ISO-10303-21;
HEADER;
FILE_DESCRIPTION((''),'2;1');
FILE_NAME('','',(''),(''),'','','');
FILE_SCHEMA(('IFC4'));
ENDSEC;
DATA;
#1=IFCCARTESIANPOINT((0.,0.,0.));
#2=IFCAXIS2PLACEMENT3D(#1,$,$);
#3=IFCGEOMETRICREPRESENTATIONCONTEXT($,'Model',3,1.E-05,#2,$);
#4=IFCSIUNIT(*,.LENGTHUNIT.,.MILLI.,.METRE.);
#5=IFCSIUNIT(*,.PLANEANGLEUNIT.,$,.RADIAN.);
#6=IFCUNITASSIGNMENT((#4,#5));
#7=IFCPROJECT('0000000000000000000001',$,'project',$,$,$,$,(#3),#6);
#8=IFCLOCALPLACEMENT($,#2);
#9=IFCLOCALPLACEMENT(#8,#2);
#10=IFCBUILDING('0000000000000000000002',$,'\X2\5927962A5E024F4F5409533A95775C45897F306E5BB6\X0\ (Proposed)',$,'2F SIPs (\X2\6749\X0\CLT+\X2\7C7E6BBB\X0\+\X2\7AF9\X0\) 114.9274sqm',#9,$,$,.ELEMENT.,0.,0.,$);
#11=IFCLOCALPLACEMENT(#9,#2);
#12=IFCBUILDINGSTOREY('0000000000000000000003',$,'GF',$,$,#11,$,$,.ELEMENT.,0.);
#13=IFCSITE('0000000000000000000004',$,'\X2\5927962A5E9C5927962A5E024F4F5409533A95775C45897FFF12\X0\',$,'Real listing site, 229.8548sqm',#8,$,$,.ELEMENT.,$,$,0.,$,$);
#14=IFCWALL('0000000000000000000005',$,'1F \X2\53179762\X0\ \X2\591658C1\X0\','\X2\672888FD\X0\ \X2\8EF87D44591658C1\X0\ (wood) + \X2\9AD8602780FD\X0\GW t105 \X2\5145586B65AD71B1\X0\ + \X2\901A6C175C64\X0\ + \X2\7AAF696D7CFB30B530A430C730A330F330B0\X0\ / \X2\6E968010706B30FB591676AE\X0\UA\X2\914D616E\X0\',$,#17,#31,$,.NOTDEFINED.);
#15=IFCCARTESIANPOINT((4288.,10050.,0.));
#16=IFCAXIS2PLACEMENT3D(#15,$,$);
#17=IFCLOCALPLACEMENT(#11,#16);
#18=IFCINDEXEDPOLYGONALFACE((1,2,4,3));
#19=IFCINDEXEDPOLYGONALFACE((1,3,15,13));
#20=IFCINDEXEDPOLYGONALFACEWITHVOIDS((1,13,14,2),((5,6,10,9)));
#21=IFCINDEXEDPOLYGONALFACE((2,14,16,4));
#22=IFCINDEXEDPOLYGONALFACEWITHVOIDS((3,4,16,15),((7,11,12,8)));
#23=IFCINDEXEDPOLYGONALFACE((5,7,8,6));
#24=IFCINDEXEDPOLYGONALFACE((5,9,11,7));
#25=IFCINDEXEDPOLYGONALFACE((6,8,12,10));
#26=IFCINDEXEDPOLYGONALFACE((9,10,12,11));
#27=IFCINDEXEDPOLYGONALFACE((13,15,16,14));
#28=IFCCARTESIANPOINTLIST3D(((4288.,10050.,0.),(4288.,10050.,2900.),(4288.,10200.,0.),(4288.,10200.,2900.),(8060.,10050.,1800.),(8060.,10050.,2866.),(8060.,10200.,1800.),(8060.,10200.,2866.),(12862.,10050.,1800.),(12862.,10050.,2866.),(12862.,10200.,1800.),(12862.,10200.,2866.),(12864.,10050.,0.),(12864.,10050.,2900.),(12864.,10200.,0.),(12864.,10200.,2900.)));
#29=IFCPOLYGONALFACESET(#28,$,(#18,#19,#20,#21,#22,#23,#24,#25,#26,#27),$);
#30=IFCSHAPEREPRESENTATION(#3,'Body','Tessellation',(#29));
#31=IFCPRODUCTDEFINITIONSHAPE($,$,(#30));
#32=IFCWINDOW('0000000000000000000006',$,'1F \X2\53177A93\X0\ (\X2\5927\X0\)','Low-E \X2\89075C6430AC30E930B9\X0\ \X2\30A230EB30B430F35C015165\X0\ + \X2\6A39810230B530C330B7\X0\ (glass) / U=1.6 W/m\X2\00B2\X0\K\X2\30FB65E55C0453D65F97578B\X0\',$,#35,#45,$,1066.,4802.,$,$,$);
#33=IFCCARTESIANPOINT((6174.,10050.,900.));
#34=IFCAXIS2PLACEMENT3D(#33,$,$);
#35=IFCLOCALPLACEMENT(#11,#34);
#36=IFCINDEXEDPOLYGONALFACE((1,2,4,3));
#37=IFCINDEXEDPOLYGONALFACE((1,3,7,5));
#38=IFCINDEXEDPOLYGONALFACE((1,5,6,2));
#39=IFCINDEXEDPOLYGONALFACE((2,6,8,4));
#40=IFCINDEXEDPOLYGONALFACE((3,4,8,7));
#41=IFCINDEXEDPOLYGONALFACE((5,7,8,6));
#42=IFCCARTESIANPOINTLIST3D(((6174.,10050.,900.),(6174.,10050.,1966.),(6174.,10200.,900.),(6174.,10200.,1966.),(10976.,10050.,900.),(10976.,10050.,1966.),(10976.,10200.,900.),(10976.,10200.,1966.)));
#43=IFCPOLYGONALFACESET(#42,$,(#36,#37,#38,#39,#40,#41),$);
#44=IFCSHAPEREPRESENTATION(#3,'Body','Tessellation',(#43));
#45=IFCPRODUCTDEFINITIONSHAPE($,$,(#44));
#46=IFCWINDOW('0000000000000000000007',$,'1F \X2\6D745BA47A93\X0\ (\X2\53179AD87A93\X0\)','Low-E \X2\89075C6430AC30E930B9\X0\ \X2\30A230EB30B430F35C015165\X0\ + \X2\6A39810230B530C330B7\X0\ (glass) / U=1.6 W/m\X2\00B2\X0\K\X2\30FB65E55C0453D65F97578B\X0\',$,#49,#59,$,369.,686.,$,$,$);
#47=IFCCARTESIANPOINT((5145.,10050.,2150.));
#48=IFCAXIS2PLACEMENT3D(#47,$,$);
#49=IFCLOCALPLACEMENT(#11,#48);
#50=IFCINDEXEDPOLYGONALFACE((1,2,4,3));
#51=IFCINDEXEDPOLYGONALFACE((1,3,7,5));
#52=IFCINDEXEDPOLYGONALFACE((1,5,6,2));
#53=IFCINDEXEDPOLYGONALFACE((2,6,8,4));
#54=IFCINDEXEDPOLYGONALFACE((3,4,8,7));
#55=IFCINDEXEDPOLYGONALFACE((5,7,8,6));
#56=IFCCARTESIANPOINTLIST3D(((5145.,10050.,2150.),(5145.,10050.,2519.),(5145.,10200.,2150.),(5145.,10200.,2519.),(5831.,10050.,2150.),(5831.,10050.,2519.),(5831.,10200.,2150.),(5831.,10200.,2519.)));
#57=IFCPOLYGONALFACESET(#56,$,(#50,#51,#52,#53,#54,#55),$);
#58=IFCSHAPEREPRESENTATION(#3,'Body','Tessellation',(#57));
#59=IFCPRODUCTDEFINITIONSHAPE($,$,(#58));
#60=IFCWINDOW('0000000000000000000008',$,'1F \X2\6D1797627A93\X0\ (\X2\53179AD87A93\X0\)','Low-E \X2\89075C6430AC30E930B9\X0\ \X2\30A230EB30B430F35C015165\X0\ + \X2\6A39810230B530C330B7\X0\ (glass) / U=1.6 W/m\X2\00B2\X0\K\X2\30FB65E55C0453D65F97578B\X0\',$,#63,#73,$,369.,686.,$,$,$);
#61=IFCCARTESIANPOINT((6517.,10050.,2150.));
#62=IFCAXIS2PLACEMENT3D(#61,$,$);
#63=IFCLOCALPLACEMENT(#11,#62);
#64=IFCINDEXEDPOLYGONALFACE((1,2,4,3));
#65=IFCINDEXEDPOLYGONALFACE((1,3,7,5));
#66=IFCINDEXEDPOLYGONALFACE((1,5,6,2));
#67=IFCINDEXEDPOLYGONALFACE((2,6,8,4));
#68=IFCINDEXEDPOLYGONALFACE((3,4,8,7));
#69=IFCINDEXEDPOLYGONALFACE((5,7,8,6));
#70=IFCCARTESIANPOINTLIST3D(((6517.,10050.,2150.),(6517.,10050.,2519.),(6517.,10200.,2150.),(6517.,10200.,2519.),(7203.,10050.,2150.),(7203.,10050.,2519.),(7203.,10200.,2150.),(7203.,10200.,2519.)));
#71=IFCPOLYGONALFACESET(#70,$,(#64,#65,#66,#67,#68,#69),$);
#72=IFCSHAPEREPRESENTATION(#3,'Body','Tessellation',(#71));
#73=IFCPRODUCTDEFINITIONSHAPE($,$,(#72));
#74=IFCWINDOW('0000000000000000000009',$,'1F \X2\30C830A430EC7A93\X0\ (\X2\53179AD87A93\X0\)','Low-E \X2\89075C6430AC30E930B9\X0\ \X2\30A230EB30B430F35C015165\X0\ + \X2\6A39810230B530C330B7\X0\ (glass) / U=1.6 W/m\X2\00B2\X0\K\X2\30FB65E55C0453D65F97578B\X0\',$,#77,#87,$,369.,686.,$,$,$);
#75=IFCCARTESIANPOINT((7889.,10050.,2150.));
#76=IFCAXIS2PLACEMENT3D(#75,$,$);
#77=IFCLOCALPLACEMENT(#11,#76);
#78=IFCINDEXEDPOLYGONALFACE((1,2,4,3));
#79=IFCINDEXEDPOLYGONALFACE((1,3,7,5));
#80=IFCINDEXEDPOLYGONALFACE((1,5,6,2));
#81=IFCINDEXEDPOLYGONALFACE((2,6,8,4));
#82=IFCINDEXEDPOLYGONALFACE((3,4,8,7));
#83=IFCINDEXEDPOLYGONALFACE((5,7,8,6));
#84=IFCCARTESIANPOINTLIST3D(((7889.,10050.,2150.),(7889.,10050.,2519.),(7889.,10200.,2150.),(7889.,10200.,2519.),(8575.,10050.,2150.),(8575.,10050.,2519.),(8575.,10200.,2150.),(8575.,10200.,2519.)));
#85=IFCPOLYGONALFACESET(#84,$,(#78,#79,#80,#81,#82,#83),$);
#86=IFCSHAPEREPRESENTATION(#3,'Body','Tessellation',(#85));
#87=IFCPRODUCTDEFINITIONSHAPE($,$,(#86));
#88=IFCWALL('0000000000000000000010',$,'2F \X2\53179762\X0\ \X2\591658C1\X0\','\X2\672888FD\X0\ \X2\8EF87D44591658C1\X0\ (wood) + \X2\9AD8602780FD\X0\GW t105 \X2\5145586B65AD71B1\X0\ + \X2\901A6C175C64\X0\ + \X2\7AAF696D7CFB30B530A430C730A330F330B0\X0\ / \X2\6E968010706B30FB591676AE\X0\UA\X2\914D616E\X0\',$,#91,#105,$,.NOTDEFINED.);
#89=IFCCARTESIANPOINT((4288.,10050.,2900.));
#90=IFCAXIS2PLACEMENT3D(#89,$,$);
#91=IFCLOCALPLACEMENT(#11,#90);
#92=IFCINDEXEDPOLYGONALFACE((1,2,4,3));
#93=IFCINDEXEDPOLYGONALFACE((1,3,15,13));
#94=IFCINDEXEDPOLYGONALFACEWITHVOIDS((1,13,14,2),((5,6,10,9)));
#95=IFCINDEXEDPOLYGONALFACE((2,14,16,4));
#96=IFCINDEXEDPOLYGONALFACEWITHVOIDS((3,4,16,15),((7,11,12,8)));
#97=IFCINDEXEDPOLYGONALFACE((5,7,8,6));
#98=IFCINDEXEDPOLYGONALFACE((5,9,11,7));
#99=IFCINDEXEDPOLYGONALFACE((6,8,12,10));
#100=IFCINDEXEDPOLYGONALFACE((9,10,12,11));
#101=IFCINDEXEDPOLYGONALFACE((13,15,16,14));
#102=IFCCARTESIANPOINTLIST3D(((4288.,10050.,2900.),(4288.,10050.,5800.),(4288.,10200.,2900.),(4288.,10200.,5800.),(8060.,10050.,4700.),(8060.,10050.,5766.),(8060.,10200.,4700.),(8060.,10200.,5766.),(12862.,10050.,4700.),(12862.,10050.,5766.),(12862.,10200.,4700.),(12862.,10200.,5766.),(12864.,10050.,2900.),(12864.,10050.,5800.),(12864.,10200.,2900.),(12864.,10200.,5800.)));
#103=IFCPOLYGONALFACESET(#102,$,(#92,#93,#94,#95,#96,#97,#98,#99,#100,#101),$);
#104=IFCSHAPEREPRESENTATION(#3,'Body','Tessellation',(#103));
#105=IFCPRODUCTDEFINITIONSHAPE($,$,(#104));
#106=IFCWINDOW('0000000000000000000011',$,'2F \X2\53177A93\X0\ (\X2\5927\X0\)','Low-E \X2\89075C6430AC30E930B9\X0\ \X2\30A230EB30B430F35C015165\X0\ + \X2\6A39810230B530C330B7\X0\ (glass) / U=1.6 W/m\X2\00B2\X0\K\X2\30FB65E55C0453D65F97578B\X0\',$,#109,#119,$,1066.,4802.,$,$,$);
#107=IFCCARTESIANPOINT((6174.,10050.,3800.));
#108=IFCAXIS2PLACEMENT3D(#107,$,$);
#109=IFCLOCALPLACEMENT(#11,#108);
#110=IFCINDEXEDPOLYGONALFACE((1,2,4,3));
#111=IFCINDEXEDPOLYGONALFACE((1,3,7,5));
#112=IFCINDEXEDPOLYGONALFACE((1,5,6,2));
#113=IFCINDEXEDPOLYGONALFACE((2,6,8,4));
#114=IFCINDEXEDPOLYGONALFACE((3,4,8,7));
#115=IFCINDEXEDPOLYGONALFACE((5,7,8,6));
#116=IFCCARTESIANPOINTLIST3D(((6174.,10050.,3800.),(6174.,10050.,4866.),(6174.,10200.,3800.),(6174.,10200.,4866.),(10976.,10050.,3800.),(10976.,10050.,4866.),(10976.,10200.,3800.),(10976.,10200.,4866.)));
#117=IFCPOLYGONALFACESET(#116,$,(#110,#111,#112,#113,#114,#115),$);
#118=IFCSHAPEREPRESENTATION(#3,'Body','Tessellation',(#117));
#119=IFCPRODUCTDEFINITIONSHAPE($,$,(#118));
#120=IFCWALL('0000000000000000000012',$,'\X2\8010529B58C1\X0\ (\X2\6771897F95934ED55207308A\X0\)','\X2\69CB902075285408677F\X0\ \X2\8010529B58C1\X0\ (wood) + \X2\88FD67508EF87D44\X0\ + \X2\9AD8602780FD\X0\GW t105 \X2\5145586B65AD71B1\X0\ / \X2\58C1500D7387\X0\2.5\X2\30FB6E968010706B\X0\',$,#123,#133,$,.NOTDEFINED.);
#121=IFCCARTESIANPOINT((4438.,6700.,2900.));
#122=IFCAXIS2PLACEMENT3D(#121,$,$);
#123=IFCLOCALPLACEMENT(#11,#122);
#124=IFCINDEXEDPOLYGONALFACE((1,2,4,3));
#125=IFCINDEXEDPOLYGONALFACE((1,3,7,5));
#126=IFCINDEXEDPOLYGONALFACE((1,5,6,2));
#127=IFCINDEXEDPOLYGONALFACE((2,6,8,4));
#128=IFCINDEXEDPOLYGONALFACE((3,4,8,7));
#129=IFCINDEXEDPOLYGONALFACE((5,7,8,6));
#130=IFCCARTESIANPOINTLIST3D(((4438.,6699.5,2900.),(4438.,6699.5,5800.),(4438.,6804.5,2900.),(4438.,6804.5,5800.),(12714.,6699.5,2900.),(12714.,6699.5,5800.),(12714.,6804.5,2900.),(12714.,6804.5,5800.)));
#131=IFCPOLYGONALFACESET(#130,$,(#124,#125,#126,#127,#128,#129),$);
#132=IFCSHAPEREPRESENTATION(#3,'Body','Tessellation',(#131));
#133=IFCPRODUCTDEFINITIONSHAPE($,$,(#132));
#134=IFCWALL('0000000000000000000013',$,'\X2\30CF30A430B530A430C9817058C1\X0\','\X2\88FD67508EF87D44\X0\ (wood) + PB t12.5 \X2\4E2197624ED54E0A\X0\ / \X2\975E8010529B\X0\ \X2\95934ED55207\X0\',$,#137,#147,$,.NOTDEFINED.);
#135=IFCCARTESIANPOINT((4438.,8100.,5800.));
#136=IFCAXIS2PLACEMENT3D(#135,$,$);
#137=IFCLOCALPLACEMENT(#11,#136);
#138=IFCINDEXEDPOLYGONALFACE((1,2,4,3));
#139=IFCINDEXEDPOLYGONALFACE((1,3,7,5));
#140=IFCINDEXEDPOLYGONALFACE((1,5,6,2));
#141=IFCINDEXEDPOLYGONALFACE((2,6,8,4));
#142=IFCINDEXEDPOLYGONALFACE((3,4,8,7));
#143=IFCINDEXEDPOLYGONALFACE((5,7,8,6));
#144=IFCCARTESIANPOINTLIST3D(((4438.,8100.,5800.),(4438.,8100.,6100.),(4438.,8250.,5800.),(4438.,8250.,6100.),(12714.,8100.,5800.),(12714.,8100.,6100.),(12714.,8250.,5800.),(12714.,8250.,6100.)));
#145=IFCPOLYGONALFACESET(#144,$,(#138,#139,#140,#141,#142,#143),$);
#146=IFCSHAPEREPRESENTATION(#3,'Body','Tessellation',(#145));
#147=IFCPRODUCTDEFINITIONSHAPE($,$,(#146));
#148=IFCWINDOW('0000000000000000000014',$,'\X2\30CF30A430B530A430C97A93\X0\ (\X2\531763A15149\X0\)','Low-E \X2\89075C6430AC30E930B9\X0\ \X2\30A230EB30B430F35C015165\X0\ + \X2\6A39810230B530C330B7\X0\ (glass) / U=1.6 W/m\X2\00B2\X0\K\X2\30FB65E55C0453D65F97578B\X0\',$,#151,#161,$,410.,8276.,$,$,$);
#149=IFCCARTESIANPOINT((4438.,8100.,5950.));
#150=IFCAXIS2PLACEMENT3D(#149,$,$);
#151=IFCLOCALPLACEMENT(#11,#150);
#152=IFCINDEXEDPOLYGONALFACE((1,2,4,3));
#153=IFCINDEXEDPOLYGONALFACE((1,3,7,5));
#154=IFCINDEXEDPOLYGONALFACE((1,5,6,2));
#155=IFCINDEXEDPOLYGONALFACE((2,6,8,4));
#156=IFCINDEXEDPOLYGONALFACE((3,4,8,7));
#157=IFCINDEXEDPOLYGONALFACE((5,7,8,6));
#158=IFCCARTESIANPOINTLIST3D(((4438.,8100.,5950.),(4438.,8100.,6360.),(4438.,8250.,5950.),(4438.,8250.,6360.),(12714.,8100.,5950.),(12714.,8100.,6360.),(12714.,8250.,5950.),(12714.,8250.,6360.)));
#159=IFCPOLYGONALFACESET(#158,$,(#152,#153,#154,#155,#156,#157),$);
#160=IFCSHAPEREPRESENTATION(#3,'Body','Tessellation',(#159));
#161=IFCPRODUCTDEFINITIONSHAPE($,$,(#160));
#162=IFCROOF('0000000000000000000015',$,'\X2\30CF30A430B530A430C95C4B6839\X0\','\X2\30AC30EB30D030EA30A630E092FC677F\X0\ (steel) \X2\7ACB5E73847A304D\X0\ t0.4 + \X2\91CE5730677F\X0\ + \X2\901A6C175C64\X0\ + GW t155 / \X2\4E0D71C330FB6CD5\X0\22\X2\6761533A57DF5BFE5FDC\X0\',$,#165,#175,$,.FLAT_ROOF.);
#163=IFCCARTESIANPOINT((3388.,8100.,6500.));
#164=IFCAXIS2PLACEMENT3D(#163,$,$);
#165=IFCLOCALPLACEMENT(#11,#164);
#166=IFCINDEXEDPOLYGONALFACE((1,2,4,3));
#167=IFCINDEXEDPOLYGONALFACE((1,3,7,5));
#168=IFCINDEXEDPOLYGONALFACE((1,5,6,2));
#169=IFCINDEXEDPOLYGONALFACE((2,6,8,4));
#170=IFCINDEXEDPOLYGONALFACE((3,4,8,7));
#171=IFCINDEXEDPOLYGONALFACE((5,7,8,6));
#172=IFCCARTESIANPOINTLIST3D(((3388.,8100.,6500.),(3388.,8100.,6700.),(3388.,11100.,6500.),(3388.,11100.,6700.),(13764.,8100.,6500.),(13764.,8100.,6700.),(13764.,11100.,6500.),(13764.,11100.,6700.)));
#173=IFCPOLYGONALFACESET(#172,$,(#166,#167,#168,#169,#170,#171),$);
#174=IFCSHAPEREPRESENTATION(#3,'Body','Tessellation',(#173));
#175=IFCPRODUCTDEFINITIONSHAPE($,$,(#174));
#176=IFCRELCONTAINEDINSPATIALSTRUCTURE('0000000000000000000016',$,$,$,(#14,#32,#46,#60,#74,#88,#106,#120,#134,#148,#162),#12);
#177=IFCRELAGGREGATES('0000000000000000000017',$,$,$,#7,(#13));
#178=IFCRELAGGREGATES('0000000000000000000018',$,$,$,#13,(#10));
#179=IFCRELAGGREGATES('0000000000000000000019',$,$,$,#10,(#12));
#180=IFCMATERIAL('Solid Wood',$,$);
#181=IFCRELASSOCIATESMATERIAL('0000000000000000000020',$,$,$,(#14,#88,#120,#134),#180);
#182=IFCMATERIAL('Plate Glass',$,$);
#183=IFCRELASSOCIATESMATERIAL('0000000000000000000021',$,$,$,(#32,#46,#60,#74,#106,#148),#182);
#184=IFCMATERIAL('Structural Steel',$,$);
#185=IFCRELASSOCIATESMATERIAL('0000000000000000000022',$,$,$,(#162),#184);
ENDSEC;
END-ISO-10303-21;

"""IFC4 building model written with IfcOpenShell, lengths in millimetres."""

from ifc_helpers import new_model, si_unit, frame, frame_2d, origin, place, context, project, spatial, rectangle, extrude, material, element, fill, save


model = new_model("IFC4")

# Units and contexts
model_context = context("Model", 3, precision=1e-05, world=origin())
ifc_project = project(units=[si_unit("LENGTHUNIT", "METRE", prefix="MILLI"), si_unit("PLANEANGLEUNIT", "RADIAN")], contexts=[model_context])

# Site, building, storey
site_placement = place(None, origin())
site = spatial("IfcSite", under=ifc_project, at=site_placement, Name="大阪府大阪市住吉区長居西２", ObjectType="Real listing site, 229.8548sqm", CompositionType="ELEMENT", RefElevation=0.0)
building_placement = place(site_placement, origin())
building = spatial("IfcBuilding", under=site, at=building_placement, Name="大阪市住吉区長居西の家 (Proposed)", ObjectType="2F SIPs (杉CLT+籾殻+竹) 114.9274sqm", CompositionType="ELEMENT", ElevationOfRefHeight=0.0, ElevationOfTerrain=0.0)
storey_placement = place(building_placement, origin())
storey = spatial("IfcBuildingStorey", under=building, at=storey_placement, Name="GF", CompositionType="ELEMENT", Elevation=0.0)

# Wall, openings, windows
ifc_material_1 = material(Name="Solid Wood")
wall_1_placement = place(storey_placement, frame((4288.0, 10050.0, 0.0)))
wall_1 = element("IfcWall", 1, at=wall_1_placement, inside=storey, material=ifc_material_1, Name="1F 北面 外壁", Description="木製 軸組外壁 (wood) + 高性能GW t105 充填断熱 + 通気層 + 窯業系サイディング / 準耐火・外皮UA配慮", PredefinedType="NOTDEFINED", context=model_context, shape_type="SweptSolid", body=[
    extrude(rectangle(XDim=8576.0, YDim=150.0, at=frame_2d((4288.0, 75.0))), frame((4288.0, 10050.0, 0.0)), (0.0, 0.0, 1.0), 2900.0),
])
opening_1_placement = place(storey_placement, frame((6174.0, 10050.0, 900.0)))
opening_1 = element("IfcOpeningElement", 2, at=opening_1_placement, cuts=wall_1, PredefinedType="NOTDEFINED", context=model_context, shape_type="SweptSolid", body=[
    extrude(rectangle(XDim=4802.0, YDim=150.0, at=frame_2d((2401.0, 75.0))), frame((6174.0, 10050.0, 900.0)), (0.0, 0.0, 1.0), 1066.0),
])
opening_2_placement = place(storey_placement, frame((5145.0, 10050.0, 2150.0)))
opening_2 = element("IfcOpeningElement", 3, at=opening_2_placement, cuts=wall_1, PredefinedType="NOTDEFINED", context=model_context, shape_type="SweptSolid", body=[
    extrude(rectangle(XDim=686.0, YDim=150.0, at=frame_2d((343.0, 75.0))), frame((5145.0, 10050.0, 2150.0)), (0.0, 0.0, 1.0), 369.0),
])
opening_3_placement = place(storey_placement, frame((6517.0, 10050.0, 2150.0)))
opening_3 = element("IfcOpeningElement", 4, at=opening_3_placement, cuts=wall_1, PredefinedType="NOTDEFINED", context=model_context, shape_type="SweptSolid", body=[
    extrude(rectangle(XDim=686.0, YDim=150.0, at=frame_2d((343.0, 75.0))), frame((6517.0, 10050.0, 2150.0)), (0.0, 0.0, 1.0), 369.0),
])
opening_4_placement = place(storey_placement, frame((7889.0, 10050.0, 2150.0)))
opening_4 = element("IfcOpeningElement", 5, at=opening_4_placement, cuts=wall_1, PredefinedType="NOTDEFINED", context=model_context, shape_type="SweptSolid", body=[
    extrude(rectangle(XDim=686.0, YDim=150.0, at=frame_2d((343.0, 75.0))), frame((7889.0, 10050.0, 2150.0)), (0.0, 0.0, 1.0), 369.0),
])
ifc_material_2 = material(Name="Plate Glass")
window_1_placement = place(storey_placement, frame((6174.0, 10050.0, 900.0)))
window_1 = element("IfcWindow", 6, at=window_1_placement, inside=storey, material=ifc_material_2, Name="1F 北窓 (大)", Description="Low-E 複層ガラス アルゴン封入 + 樹脂サッシ (glass) / U=1.6 W/m²K・日射取得型", OverallHeight=1066.0, OverallWidth=4802.0, context=model_context, shape_type="SweptSolid", body=[
    extrude(rectangle(XDim=4802.0, YDim=150.0, at=frame_2d((2401.0, 75.0))), frame((6174.0, 10050.0, 900.0)), (0.0, 0.0, 1.0), 1066.0),
])
fill(opening_1, window_1)
window_2_placement = place(storey_placement, frame((5145.0, 10050.0, 2150.0)))
window_2 = element("IfcWindow", 7, at=window_2_placement, inside=storey, material=ifc_material_2, Name="1F 浴室窓 (北高窓)", Description="Low-E 複層ガラス アルゴン封入 + 樹脂サッシ (glass) / U=1.6 W/m²K・日射取得型", OverallHeight=369.0, OverallWidth=686.0, context=model_context, shape_type="SweptSolid", body=[
    extrude(rectangle(XDim=686.0, YDim=150.0, at=frame_2d((343.0, 75.0))), frame((5145.0, 10050.0, 2150.0)), (0.0, 0.0, 1.0), 369.0),
])
fill(opening_2, window_2)
window_3_placement = place(storey_placement, frame((6517.0, 10050.0, 2150.0)))
window_3 = element("IfcWindow", 8, at=window_3_placement, inside=storey, material=ifc_material_2, Name="1F 洗面窓 (北高窓)", Description="Low-E 複層ガラス アルゴン封入 + 樹脂サッシ (glass) / U=1.6 W/m²K・日射取得型", OverallHeight=369.0, OverallWidth=686.0, context=model_context, shape_type="SweptSolid", body=[
    extrude(rectangle(XDim=686.0, YDim=150.0, at=frame_2d((343.0, 75.0))), frame((6517.0, 10050.0, 2150.0)), (0.0, 0.0, 1.0), 369.0),
])
fill(opening_3, window_3)
window_4_placement = place(storey_placement, frame((7889.0, 10050.0, 2150.0)))
window_4 = element("IfcWindow", 9, at=window_4_placement, inside=storey, material=ifc_material_2, Name="1F トイレ窓 (北高窓)", Description="Low-E 複層ガラス アルゴン封入 + 樹脂サッシ (glass) / U=1.6 W/m²K・日射取得型", OverallHeight=369.0, OverallWidth=686.0, context=model_context, shape_type="SweptSolid", body=[
    extrude(rectangle(XDim=686.0, YDim=150.0, at=frame_2d((343.0, 75.0))), frame((7889.0, 10050.0, 2150.0)), (0.0, 0.0, 1.0), 369.0),
])
fill(opening_4, window_4)

# Wall, opening, window
wall_2_placement = place(storey_placement, frame((4288.0, 10050.0, 2900.0)))
wall_2 = element("IfcWall", 10, at=wall_2_placement, inside=storey, material=ifc_material_1, Name="2F 北面 外壁", Description="木製 軸組外壁 (wood) + 高性能GW t105 充填断熱 + 通気層 + 窯業系サイディング / 準耐火・外皮UA配慮", PredefinedType="NOTDEFINED", context=model_context, shape_type="SweptSolid", body=[
    extrude(rectangle(XDim=8576.0, YDim=150.0, at=frame_2d((4288.0, 75.0))), frame((4288.0, 10050.0, 2900.0)), (0.0, 0.0, 1.0), 2900.0),
])
opening_5_placement = place(storey_placement, frame((6174.0, 10050.0, 3800.0)))
opening_5 = element("IfcOpeningElement", 11, at=opening_5_placement, cuts=wall_2, PredefinedType="NOTDEFINED", context=model_context, shape_type="SweptSolid", body=[
    extrude(rectangle(XDim=4802.0, YDim=150.0, at=frame_2d((2401.0, 75.0))), frame((6174.0, 10050.0, 3800.0)), (0.0, 0.0, 1.0), 1066.0),
])
window_5_placement = place(storey_placement, frame((6174.0, 10050.0, 3800.0)))
window_5 = element("IfcWindow", 12, at=window_5_placement, inside=storey, material=ifc_material_2, Name="2F 北窓 (大)", Description="Low-E 複層ガラス アルゴン封入 + 樹脂サッシ (glass) / U=1.6 W/m²K・日射取得型", OverallHeight=1066.0, OverallWidth=4802.0, context=model_context, shape_type="SweptSolid", body=[
    extrude(rectangle(XDim=4802.0, YDim=150.0, at=frame_2d((2401.0, 75.0))), frame((6174.0, 10050.0, 3800.0)), (0.0, 0.0, 1.0), 1066.0),
])
fill(opening_5, window_5)

# Wall
wall_3_placement = place(storey_placement, frame((4438.0, 6700.0, 2900.0)))
element("IfcWall", 13, at=wall_3_placement, inside=storey, material=ifc_material_1, Name="耐力壁 (東西間仕切り)", Description="構造用合板 耐力壁 (wood) + 製材軸組 + 高性能GW t105 充填断熱 / 壁倍率2.5・準耐火", PredefinedType="NOTDEFINED", context=model_context, shape_type="SweptSolid", body=[
    extrude(rectangle(XDim=8276.0, YDim=105.0, at=frame_2d((4138.0, 52.0))), frame((4438.0, 6700.0, 2900.0)), (0.0, 0.0, 1.0), 2900.0),
])

# Wall, opening, window
wall_4_placement = place(storey_placement, frame((4438.0, 8100.0, 5800.0)))
wall_4 = element("IfcWall", 14, at=wall_4_placement, inside=storey, material=ifc_material_1, Name="ハイサイド腰壁", Description="製材軸組 (wood) + PB t12.5 両面仕上 / 非耐力 間仕切", PredefinedType="NOTDEFINED", context=model_context, shape_type="SweptSolid", body=[
    extrude(rectangle(XDim=8276.0, YDim=150.0, at=frame_2d((4138.0, 75.0))), frame((4438.0, 8100.0, 5800.0)), (0.0, 0.0, 1.0), 700.0),
])
opening_6_placement = place(storey_placement, frame((4438.0, 8100.0, 5950.0)))
opening_6 = element("IfcOpeningElement", 15, at=opening_6_placement, cuts=wall_4, PredefinedType="NOTDEFINED", context=model_context, shape_type="SweptSolid", body=[
    extrude(rectangle(XDim=8276.0, YDim=150.0, at=frame_2d((4138.0, 75.0))), frame((4438.0, 8100.0, 5950.0)), (0.0, 0.0, 1.0), 410.0),
])
window_6_placement = place(storey_placement, frame((4438.0, 8100.0, 5950.0)))
window_6 = element("IfcWindow", 16, at=window_6_placement, inside=storey, material=ifc_material_2, Name="ハイサイド窓 (北採光)", Description="Low-E 複層ガラス アルゴン封入 + 樹脂サッシ (glass) / U=1.6 W/m²K・日射取得型", OverallHeight=410.0, OverallWidth=8276.0, context=model_context, shape_type="SweptSolid", body=[
    extrude(rectangle(XDim=8276.0, YDim=150.0, at=frame_2d((4138.0, 75.0))), frame((4438.0, 8100.0, 5950.0)), (0.0, 0.0, 1.0), 410.0),
])
fill(opening_6, window_6)

# Roof
ifc_material_3 = material(Name="Structural Steel")
roof_placement = place(storey_placement, frame((3388.0, 8100.0, 6500.0)))
element("IfcRoof", 17, at=roof_placement, inside=storey, material=ifc_material_3, Name="ハイサイド屋根", Description="ガルバリウム鋼板 (steel) 立平葺き t0.4 + 野地板 + 通気層 + GW t155 / 不燃・法22条区域対応", PredefinedType="FLAT_ROOF", context=model_context, shape_type="SweptSolid", body=[
    extrude(rectangle(XDim=10376.0, YDim=3000.0, at=frame_2d((5188.0, 1500.0))), frame((3388.0, 8100.0, 6500.0)), (0.0, 0.0, 1.0), 200.0),
])

save(model, "model.ifc")
